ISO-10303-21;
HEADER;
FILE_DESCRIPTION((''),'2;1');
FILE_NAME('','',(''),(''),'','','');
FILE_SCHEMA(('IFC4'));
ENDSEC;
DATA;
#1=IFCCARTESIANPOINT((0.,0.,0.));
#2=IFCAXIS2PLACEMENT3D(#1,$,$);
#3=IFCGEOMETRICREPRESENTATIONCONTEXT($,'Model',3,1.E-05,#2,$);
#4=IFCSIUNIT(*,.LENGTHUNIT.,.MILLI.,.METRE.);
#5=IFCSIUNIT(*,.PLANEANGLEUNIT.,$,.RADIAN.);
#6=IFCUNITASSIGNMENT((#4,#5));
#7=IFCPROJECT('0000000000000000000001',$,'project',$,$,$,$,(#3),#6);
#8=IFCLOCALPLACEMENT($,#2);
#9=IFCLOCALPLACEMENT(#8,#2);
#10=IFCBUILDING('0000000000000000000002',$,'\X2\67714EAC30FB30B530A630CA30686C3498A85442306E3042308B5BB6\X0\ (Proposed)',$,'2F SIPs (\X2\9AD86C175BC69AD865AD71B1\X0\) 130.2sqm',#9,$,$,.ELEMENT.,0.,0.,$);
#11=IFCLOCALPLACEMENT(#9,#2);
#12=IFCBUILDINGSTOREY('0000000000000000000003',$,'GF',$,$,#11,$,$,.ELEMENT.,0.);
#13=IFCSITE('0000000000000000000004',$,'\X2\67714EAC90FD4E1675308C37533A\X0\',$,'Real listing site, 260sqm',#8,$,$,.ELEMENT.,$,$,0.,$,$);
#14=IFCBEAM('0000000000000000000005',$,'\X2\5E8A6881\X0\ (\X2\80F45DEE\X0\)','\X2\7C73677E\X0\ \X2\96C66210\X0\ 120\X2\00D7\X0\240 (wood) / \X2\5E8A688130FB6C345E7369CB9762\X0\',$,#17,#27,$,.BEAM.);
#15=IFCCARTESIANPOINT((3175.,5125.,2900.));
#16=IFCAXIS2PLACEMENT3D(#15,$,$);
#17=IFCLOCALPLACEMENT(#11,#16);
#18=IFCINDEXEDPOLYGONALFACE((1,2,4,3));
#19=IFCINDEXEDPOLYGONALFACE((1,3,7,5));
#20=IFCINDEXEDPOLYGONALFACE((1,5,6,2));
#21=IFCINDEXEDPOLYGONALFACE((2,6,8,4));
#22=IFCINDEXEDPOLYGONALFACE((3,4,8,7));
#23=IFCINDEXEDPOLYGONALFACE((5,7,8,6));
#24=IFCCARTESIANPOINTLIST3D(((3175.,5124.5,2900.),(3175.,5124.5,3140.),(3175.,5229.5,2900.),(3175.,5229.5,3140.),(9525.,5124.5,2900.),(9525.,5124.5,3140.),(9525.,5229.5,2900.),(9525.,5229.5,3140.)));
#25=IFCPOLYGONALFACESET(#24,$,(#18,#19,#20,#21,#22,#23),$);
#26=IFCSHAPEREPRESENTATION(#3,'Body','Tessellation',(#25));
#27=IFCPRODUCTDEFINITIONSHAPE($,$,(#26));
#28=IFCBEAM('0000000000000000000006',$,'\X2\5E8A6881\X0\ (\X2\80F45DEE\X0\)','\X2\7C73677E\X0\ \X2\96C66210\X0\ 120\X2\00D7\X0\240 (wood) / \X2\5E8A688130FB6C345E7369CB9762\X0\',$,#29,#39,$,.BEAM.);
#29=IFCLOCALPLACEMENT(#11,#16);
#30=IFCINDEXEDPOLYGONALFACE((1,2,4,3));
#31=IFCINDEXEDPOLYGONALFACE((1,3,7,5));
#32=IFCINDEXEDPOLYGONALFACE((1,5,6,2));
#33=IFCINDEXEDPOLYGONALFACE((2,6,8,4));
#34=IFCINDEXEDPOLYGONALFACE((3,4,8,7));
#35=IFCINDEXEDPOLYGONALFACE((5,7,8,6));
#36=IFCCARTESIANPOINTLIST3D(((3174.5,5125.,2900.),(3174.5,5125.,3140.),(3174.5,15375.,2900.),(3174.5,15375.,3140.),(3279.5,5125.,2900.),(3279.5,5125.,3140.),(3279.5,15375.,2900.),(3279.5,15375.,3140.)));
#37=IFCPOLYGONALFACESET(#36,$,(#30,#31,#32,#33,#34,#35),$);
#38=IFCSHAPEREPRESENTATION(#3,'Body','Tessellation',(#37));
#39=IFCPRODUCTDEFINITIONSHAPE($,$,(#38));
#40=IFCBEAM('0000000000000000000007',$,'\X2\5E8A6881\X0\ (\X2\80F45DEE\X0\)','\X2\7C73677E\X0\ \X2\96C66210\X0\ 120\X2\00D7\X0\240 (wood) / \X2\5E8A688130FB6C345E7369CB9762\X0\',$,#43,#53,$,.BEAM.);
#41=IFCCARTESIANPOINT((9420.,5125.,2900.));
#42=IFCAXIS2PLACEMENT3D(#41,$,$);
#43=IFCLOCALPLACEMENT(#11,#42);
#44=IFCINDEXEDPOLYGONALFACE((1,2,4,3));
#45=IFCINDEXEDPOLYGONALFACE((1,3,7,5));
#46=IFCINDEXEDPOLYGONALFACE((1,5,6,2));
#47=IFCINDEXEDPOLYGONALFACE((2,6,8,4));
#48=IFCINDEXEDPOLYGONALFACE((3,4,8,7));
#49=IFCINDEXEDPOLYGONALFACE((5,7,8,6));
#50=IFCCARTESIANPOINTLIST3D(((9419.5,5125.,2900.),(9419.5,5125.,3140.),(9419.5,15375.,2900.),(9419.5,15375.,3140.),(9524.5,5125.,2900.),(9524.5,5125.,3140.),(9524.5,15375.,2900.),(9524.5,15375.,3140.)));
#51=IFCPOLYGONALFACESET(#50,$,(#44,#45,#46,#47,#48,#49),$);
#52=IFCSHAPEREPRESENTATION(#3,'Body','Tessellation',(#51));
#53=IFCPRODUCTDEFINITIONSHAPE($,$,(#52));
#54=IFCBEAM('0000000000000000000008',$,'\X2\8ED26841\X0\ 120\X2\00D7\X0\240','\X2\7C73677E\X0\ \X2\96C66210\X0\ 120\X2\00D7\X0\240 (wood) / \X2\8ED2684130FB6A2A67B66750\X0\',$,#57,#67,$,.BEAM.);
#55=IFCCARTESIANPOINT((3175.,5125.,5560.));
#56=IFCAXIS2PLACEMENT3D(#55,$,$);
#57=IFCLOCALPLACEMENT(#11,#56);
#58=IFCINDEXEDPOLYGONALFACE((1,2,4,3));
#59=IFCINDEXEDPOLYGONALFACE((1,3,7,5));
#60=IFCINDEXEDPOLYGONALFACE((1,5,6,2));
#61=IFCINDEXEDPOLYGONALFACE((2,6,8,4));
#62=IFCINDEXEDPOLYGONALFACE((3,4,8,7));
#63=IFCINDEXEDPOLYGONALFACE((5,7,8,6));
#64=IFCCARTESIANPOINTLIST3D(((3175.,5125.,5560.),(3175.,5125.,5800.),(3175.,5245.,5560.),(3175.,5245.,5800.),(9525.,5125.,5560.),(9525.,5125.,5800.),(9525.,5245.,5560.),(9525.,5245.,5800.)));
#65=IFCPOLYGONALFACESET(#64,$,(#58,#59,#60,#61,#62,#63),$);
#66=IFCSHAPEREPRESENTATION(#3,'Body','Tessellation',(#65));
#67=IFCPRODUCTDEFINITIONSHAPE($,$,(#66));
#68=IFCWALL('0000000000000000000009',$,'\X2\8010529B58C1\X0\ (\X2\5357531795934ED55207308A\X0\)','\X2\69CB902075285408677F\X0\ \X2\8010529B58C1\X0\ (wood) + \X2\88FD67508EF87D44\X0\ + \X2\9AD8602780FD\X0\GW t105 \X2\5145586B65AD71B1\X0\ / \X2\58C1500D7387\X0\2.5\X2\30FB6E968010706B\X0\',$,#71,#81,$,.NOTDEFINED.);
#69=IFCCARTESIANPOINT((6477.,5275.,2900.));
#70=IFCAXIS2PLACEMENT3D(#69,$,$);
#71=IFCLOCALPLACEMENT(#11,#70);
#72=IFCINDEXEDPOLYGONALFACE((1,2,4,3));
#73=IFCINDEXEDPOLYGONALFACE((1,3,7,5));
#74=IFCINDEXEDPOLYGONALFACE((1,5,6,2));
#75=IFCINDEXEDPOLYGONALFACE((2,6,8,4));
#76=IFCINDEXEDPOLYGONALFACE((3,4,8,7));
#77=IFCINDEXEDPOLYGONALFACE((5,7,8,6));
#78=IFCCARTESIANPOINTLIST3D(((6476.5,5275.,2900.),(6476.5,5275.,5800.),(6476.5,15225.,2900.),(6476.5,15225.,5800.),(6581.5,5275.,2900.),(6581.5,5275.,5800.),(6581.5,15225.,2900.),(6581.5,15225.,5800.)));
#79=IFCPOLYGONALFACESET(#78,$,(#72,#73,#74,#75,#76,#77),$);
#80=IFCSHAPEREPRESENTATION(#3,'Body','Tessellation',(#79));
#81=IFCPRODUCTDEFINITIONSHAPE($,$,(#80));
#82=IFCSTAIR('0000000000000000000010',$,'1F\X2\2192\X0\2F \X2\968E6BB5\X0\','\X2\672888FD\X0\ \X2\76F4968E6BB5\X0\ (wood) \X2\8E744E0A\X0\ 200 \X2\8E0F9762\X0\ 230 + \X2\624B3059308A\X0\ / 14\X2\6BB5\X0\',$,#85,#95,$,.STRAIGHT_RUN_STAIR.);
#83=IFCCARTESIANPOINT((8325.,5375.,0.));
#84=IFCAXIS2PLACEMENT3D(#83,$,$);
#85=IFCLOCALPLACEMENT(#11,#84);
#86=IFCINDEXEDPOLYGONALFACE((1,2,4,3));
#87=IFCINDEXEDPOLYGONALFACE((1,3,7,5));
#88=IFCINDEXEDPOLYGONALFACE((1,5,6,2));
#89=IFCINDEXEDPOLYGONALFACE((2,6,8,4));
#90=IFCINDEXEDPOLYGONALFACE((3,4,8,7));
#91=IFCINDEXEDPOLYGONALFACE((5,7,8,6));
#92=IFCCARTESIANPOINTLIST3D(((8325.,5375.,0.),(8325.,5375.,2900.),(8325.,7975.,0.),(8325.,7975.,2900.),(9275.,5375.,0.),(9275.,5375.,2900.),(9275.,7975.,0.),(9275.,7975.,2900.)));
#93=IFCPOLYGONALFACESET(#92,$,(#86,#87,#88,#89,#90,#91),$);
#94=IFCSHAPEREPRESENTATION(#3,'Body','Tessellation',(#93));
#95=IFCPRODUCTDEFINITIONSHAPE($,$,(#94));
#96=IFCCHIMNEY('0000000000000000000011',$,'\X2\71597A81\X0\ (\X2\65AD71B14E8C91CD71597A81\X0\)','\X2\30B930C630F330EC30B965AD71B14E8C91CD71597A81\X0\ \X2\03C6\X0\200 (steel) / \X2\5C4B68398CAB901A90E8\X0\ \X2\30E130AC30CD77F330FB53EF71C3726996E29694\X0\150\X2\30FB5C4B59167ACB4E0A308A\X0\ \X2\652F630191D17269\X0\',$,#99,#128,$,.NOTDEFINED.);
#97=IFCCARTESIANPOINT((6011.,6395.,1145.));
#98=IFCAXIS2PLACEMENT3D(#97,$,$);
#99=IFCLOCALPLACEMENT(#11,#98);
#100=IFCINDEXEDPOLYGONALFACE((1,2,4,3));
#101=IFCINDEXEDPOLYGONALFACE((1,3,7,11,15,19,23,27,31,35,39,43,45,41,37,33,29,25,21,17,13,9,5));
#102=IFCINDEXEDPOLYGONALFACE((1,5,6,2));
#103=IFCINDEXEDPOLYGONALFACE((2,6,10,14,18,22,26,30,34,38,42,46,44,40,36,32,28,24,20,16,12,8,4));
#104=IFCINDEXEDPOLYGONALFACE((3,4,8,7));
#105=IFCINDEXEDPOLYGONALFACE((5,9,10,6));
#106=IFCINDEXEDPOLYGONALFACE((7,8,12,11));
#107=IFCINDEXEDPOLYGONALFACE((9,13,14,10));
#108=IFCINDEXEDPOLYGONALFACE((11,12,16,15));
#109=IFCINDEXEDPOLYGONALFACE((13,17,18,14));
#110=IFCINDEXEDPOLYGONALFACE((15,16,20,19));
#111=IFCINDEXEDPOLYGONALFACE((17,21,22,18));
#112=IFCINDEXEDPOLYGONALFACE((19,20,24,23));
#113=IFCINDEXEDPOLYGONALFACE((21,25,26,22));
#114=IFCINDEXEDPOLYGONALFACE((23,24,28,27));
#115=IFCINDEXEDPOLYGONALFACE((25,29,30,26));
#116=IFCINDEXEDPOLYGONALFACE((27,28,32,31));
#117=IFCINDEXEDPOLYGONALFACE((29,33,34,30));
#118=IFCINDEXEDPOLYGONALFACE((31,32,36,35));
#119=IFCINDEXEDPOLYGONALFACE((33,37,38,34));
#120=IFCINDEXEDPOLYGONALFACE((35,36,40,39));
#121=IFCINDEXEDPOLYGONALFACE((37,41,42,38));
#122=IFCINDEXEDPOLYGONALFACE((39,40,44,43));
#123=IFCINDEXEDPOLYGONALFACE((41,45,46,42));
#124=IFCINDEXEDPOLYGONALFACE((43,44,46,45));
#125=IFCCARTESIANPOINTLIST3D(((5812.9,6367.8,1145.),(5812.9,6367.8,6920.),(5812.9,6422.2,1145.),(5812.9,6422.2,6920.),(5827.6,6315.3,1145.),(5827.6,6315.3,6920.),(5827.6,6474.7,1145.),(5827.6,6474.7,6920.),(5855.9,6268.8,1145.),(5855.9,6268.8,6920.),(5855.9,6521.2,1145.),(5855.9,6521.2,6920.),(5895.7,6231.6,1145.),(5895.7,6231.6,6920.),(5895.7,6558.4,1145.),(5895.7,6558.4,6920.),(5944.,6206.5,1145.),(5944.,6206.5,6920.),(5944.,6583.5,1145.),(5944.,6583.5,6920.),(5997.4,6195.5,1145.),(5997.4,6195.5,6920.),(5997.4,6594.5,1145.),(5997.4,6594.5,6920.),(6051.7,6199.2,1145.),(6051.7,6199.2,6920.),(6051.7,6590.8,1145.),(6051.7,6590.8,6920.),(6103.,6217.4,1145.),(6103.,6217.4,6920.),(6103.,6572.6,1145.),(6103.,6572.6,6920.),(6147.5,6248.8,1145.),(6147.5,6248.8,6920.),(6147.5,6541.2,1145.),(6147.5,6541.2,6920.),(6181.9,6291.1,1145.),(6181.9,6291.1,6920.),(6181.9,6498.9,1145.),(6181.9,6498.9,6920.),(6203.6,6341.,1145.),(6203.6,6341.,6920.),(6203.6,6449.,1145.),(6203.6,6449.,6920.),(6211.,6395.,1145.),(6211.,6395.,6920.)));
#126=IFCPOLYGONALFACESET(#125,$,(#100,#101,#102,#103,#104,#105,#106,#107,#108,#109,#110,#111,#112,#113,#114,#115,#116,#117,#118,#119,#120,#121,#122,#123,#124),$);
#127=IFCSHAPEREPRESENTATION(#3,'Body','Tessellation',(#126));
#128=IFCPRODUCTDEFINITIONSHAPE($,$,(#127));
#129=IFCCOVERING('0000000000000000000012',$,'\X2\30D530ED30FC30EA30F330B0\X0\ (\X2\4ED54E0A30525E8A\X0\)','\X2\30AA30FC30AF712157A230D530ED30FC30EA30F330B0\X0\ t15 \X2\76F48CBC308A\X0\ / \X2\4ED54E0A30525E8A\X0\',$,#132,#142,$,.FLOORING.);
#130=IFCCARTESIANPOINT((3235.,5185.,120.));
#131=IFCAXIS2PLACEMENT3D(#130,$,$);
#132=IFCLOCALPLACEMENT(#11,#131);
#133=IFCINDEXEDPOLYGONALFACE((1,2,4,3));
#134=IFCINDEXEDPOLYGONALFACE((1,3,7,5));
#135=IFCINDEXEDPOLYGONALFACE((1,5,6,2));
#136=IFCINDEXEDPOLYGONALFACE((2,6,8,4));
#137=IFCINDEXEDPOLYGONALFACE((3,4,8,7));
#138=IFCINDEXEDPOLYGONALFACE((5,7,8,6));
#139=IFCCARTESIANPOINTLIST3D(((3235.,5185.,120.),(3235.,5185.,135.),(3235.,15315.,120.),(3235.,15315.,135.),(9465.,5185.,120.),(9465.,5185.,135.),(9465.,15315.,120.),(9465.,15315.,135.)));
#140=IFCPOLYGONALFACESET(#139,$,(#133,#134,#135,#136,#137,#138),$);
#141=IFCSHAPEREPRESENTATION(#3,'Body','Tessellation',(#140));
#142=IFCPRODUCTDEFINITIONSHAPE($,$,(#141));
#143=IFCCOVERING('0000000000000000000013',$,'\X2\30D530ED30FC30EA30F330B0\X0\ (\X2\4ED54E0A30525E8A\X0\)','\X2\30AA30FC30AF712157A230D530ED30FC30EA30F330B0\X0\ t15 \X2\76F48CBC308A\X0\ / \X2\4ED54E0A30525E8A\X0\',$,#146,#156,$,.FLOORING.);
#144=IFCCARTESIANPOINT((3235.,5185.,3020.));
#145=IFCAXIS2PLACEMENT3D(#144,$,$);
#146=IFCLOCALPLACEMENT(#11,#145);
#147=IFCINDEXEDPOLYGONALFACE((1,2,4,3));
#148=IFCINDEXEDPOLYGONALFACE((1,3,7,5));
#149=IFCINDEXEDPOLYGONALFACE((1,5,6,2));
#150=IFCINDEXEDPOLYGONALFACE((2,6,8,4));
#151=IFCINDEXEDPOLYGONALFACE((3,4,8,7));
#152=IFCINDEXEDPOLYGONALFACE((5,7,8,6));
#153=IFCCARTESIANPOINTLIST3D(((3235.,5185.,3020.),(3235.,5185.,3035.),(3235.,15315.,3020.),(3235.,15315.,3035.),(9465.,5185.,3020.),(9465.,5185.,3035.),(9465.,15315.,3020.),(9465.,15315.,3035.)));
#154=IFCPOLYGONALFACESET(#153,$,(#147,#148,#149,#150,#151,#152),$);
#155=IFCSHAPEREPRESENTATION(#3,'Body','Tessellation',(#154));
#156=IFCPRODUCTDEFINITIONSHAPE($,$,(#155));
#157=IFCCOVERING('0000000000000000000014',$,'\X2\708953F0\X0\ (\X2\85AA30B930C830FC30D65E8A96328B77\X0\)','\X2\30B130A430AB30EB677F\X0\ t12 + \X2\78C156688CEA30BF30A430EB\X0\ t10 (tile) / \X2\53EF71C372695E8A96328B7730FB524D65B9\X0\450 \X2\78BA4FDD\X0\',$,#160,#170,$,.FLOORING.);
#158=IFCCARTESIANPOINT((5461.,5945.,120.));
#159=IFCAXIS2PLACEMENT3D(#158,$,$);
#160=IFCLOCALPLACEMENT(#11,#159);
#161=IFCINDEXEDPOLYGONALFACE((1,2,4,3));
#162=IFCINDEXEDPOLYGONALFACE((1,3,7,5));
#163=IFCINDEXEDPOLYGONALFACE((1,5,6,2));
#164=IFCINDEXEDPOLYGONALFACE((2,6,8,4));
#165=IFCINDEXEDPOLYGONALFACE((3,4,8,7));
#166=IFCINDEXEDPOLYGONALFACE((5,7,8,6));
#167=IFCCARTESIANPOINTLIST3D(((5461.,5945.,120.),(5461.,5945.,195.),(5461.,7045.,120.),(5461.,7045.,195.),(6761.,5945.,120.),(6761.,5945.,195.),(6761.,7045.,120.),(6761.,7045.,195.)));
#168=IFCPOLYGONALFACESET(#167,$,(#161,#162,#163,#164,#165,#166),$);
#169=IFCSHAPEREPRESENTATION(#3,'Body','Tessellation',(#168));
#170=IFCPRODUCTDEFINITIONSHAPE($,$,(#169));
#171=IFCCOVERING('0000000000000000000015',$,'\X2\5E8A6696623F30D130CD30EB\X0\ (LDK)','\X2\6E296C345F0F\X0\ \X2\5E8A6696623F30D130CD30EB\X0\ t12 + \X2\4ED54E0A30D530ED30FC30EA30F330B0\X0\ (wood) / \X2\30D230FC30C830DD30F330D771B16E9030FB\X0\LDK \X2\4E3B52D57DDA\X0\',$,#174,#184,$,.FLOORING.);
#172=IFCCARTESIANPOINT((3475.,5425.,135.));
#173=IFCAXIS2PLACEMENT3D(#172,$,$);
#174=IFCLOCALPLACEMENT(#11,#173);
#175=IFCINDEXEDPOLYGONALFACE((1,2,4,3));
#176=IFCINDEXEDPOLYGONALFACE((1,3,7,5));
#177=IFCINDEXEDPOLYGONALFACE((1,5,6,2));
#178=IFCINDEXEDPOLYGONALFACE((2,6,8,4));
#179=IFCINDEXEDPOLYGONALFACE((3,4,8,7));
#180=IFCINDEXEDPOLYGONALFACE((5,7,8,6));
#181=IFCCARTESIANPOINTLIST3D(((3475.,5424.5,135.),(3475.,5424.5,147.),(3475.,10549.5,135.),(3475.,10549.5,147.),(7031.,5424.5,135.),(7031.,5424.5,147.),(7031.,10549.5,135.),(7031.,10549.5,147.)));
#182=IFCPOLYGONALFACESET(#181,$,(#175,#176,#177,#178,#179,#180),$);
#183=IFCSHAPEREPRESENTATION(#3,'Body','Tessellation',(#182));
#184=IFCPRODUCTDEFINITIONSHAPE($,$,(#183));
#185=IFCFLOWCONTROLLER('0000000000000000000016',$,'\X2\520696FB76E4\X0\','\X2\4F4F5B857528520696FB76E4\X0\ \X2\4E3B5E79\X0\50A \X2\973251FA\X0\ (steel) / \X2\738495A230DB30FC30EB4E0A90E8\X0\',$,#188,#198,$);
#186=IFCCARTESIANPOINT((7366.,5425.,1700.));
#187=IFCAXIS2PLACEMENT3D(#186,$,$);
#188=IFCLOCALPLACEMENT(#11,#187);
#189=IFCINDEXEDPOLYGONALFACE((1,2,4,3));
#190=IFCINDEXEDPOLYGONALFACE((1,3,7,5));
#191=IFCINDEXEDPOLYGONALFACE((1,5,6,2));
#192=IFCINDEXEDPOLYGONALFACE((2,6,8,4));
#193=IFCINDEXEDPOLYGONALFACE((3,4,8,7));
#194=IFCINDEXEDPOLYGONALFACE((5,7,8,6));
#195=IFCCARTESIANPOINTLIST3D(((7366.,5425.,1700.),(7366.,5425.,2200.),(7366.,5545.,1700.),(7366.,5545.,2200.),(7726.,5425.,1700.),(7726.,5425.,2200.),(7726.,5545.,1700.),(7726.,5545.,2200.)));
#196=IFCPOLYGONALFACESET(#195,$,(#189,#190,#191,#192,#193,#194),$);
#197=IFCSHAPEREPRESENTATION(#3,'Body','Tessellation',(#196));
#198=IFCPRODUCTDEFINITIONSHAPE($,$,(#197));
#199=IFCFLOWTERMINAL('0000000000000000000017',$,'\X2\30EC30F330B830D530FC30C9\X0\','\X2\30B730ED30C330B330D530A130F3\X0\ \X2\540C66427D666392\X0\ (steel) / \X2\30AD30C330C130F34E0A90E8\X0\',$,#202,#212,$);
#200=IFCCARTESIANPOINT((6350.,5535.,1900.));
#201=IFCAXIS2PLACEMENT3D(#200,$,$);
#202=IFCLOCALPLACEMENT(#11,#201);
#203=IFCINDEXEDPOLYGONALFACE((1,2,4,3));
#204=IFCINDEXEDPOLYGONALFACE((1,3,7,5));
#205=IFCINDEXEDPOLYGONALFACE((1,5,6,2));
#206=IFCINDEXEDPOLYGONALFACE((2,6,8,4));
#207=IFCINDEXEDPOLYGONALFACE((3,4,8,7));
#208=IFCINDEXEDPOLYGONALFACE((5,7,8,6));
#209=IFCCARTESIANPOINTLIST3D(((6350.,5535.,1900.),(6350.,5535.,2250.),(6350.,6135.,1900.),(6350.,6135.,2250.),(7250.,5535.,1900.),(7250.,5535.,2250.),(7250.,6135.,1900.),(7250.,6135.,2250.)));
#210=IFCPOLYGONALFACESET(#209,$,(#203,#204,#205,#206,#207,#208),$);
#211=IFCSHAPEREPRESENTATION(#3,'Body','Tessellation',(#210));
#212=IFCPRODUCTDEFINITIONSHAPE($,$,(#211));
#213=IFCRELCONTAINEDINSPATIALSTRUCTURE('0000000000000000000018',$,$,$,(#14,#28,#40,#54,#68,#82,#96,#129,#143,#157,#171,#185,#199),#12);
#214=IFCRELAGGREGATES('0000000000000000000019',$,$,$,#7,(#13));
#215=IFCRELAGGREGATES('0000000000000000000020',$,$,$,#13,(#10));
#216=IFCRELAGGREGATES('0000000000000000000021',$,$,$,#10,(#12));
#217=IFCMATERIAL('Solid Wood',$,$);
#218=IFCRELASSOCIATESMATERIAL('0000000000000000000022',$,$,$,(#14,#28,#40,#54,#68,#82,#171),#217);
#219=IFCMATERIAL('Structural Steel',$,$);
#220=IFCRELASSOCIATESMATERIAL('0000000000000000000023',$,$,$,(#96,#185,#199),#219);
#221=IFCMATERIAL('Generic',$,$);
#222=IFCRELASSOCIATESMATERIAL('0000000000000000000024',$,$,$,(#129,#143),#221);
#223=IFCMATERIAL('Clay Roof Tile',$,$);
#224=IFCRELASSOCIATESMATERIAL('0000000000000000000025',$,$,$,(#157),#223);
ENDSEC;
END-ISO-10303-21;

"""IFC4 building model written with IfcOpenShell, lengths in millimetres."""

from ifc_helpers import new_model, si_unit, frame, frame_2d, origin, origin_2d, place, context, project, spatial, rectangle, circle, extrude, material, element, save


model = new_model("IFC4")

# Units and contexts
model_context = context("Model", 3, precision=1e-05, world=origin())
ifc_project = project(units=[si_unit("LENGTHUNIT", "METRE", prefix="MILLI"), si_unit("PLANEANGLEUNIT", "RADIAN")], contexts=[model_context])

# Site, building, storey
site_placement = place(None, origin())
site = spatial("IfcSite", under=ifc_project, at=site_placement, Name="東京都世田谷区", ObjectType="Real listing site, 260sqm", CompositionType="ELEMENT", RefElevation=0.0)
building_placement = place(site_placement, origin())
building = spatial("IfcBuilding", under=site, at=building_placement, Name="東京・サウナと水風呂のある家 (Proposed)", ObjectType="2F SIPs (高気密高断熱) 130.2sqm", CompositionType="ELEMENT", ElevationOfRefHeight=0.0, ElevationOfTerrain=0.0)
storey_placement = place(building_placement, origin())
storey = spatial("IfcBuildingStorey", under=building, at=storey_placement, Name="GF", CompositionType="ELEMENT", Elevation=0.0)

# Shared definitions
ifc_material_1 = material(Name="Solid Wood")

# Beams
beam_1_placement = place(storey_placement, frame((3175.0, 5125.0, 2900.0)))
element("IfcBeam", 1, at=beam_1_placement, inside=storey, material=ifc_material_1, Name="床梁 (胴差)", Description="米松 集成 120×240 (wood) / 床梁・水平構面", PredefinedType="BEAM", context=model_context, shape_type="SweptSolid", body=[
    extrude(rectangle(XDim=6350.0, YDim=105.0, at=frame_2d((3175.0, 52.0))), frame((3175.0, 5125.0, 2900.0)), (0.0, 0.0, 1.0), 240.0),
])
beam_2_placement = place(storey_placement, frame((3175.0, 5125.0, 2900.0)))
element("IfcBeam", 2, at=beam_2_placement, inside=storey, material=ifc_material_1, Name="床梁 (胴差)", Description="米松 集成 120×240 (wood) / 床梁・水平構面", PredefinedType="BEAM", context=model_context, shape_type="SweptSolid", body=[
    extrude(rectangle(XDim=105.0, YDim=10250.0, at=frame_2d((52.0, 5125.0))), frame((3175.0, 5125.0, 2900.0)), (0.0, 0.0, 1.0), 240.0),
])
beam_3_placement = place(storey_placement, frame((9420.0, 5125.0, 2900.0)))
element("IfcBeam", 3, at=beam_3_placement, inside=storey, material=ifc_material_1, Name="床梁 (胴差)", Description="米松 集成 120×240 (wood) / 床梁・水平構面", PredefinedType="BEAM", context=model_context, shape_type="SweptSolid", body=[
    extrude(rectangle(XDim=105.0, YDim=10250.0, at=frame_2d((52.0, 5125.0))), frame((9420.0, 5125.0, 2900.0)), (0.0, 0.0, 1.0), 240.0),
])
beam_4_placement = place(storey_placement, frame((3175.0, 5125.0, 5560.0)))
element("IfcBeam", 4, at=beam_4_placement, inside=storey, material=ifc_material_1, Name="軒桁 120×240", Description="米松 集成 120×240 (wood) / 軒桁・横架材", PredefinedType="BEAM", context=model_context, shape_type="SweptSolid", body=[
    extrude(rectangle(XDim=6350.0, YDim=120.0, at=frame_2d((3175.0, 60.0))), frame((3175.0, 5125.0, 5560.0)), (0.0, 0.0, 1.0), 240.0),
])

# Wall
wall_1_placement = place(storey_placement, frame((6477.0, 5275.0, 2900.0)))
element("IfcWall", 5, at=wall_1_placement, inside=storey, material=ifc_material_1, Name="耐力壁 (南北間仕切り)", Description="構造用合板 耐力壁 (wood) + 製材軸組 + 高性能GW t105 充填断熱 / 壁倍率2.5・準耐火", PredefinedType="NOTDEFINED", context=model_context, shape_type="SweptSolid", body=[
    extrude(rectangle(XDim=105.0, YDim=9950.0, at=frame_2d((52.0, 4975.0))), frame((6477.0, 5275.0, 2900.0)), (0.0, 0.0, 1.0), 2900.0),
])

# Stair
stair_placement = place(storey_placement, frame((8325.0, 5375.0, 0.0)))
element("IfcStair", 6, at=stair_placement, inside=storey, material=ifc_material_1, Name="1F→2F 階段", Description="木製 直階段 (wood) 蹴上 200 踏面 230 + 手すり / 14段", PredefinedType="STRAIGHT_RUN_STAIR", context=model_context, shape_type="SweptSolid", body=[
    extrude(rectangle(XDim=950.0, YDim=2600.0, at=frame_2d((475.0, 1300.0))), frame((8325.0, 5375.0, 0.0)), (0.0, 0.0, 1.0), 2900.0),
])

# Chimney
ifc_material_2 = material(Name="Structural Steel")
chimney_placement = place(storey_placement, frame((6011.0, 6395.0, 1145.0)))
element("IfcChimney", 7, at=chimney_placement, inside=storey, material=ifc_material_2, Name="煙突 (断熱二重煙突)", Description="ステンレス断熱二重煙突 φ200 (steel) / 屋根貫通部 メガネ石・可燃物離隔150・屋外立上り 支持金物", PredefinedType="NOTDEFINED", context=model_context, shape_type="SweptSolid", body=[
    extrude(circle(Radius=200.0, at=origin_2d()), frame((6011.0, 6395.0, 1145.0)), (0.0, 0.0, 1.0), 5775.0),
])

# Coverings
ifc_material_3 = material(Name="Generic")
covering_1_placement = place(storey_placement, frame((3235.0, 5185.0, 120.0)))
element("IfcCovering", 8, at=covering_1_placement, inside=storey, material=ifc_material_3, Name="フローリング (仕上げ床)", Description="オーク無垢フローリング t15 直貼り / 仕上げ床", PredefinedType="FLOORING", context=model_context, shape_type="SweptSolid", body=[
    extrude(rectangle(XDim=6230.0, YDim=10130.0, at=frame_2d((3115.0, 5065.0))), frame((3235.0, 5185.0, 120.0)), (0.0, 0.0, 1.0), 15.0),
])
covering_2_placement = place(storey_placement, frame((3235.0, 5185.0, 3020.0)))
element("IfcCovering", 9, at=covering_2_placement, inside=storey, material=ifc_material_3, Name="フローリング (仕上げ床)", Description="オーク無垢フローリング t15 直貼り / 仕上げ床", PredefinedType="FLOORING", context=model_context, shape_type="SweptSolid", body=[
    extrude(rectangle(XDim=6230.0, YDim=10130.0, at=frame_2d((3115.0, 5065.0))), frame((3235.0, 5185.0, 3020.0)), (0.0, 0.0, 1.0), 15.0),
])
ifc_material_4 = material(Name="Clay Roof Tile")
covering_3_placement = place(storey_placement, frame((5461.0, 5945.0, 120.0)))
element("IfcCovering", 10, at=covering_3_placement, inside=storey, material=ifc_material_4, Name="炉台 (薪ストーブ床防護)", Description="ケイカル板 t12 + 磁器質タイル t10 (tile) / 可燃物床防護・前方450 確保", PredefinedType="FLOORING", context=model_context, shape_type="SweptSolid", body=[
    extrude(rectangle(XDim=1300.0, YDim=1100.0, at=frame_2d((650.0, 550.0))), frame((5461.0, 5945.0, 120.0)), (0.0, 0.0, 1.0), 75.0),
])
covering_4_placement = place(storey_placement, frame((3475.0, 5425.0, 135.0)))
element("IfcCovering", 11, at=covering_4_placement, inside=storey, material=ifc_material_1, Name="床暖房パネル (LDK)", Description="温水式 床暖房パネル t12 + 仕上フローリング (wood) / ヒートポンプ熱源・LDK 主動線", PredefinedType="FLOORING", context=model_context, shape_type="SweptSolid", body=[
    extrude(rectangle(XDim=3556.0, YDim=5125.0, at=frame_2d((1778.0, 2562.0))), frame((3475.0, 5425.0, 135.0)), (0.0, 0.0, 1.0), 12.0),
])

# Flow controller
flow_controller_placement = place(storey_placement, frame((7366.0, 5425.0, 1700.0)))
element("IfcFlowController", 12, at=flow_controller_placement, inside=storey, material=ifc_material_2, Name="分電盤", Description="住宅用分電盤 主幹50A 露出 (steel) / 玄関ホール上部", context=model_context, shape_type="SweptSolid", body=[
    extrude(rectangle(XDim=360.0, YDim=120.0, at=frame_2d((180.0, 60.0))), frame((7366.0, 5425.0, 1700.0)), (0.0, 0.0, 1.0), 500.0),
])

# Flow terminal
flow_terminal_1_placement = place(storey_placement, frame((6350.0, 5535.0, 1900.0)))
element("IfcFlowTerminal", 13, at=flow_terminal_1_placement, inside=storey, material=ifc_material_2, Name="レンジフード", Description="シロッコファン 同時給排 (steel) / キッチン上部", context=model_context, shape_type="SweptSolid", body=[
    extrude(rectangle(XDim=900.0, YDim=600.0, at=frame_2d((450.0, 300.0))), frame((6350.0, 5535.0, 1900.0)), (0.0, 0.0, 1.0), 350.0),
])

save(model, "model.ifc")
